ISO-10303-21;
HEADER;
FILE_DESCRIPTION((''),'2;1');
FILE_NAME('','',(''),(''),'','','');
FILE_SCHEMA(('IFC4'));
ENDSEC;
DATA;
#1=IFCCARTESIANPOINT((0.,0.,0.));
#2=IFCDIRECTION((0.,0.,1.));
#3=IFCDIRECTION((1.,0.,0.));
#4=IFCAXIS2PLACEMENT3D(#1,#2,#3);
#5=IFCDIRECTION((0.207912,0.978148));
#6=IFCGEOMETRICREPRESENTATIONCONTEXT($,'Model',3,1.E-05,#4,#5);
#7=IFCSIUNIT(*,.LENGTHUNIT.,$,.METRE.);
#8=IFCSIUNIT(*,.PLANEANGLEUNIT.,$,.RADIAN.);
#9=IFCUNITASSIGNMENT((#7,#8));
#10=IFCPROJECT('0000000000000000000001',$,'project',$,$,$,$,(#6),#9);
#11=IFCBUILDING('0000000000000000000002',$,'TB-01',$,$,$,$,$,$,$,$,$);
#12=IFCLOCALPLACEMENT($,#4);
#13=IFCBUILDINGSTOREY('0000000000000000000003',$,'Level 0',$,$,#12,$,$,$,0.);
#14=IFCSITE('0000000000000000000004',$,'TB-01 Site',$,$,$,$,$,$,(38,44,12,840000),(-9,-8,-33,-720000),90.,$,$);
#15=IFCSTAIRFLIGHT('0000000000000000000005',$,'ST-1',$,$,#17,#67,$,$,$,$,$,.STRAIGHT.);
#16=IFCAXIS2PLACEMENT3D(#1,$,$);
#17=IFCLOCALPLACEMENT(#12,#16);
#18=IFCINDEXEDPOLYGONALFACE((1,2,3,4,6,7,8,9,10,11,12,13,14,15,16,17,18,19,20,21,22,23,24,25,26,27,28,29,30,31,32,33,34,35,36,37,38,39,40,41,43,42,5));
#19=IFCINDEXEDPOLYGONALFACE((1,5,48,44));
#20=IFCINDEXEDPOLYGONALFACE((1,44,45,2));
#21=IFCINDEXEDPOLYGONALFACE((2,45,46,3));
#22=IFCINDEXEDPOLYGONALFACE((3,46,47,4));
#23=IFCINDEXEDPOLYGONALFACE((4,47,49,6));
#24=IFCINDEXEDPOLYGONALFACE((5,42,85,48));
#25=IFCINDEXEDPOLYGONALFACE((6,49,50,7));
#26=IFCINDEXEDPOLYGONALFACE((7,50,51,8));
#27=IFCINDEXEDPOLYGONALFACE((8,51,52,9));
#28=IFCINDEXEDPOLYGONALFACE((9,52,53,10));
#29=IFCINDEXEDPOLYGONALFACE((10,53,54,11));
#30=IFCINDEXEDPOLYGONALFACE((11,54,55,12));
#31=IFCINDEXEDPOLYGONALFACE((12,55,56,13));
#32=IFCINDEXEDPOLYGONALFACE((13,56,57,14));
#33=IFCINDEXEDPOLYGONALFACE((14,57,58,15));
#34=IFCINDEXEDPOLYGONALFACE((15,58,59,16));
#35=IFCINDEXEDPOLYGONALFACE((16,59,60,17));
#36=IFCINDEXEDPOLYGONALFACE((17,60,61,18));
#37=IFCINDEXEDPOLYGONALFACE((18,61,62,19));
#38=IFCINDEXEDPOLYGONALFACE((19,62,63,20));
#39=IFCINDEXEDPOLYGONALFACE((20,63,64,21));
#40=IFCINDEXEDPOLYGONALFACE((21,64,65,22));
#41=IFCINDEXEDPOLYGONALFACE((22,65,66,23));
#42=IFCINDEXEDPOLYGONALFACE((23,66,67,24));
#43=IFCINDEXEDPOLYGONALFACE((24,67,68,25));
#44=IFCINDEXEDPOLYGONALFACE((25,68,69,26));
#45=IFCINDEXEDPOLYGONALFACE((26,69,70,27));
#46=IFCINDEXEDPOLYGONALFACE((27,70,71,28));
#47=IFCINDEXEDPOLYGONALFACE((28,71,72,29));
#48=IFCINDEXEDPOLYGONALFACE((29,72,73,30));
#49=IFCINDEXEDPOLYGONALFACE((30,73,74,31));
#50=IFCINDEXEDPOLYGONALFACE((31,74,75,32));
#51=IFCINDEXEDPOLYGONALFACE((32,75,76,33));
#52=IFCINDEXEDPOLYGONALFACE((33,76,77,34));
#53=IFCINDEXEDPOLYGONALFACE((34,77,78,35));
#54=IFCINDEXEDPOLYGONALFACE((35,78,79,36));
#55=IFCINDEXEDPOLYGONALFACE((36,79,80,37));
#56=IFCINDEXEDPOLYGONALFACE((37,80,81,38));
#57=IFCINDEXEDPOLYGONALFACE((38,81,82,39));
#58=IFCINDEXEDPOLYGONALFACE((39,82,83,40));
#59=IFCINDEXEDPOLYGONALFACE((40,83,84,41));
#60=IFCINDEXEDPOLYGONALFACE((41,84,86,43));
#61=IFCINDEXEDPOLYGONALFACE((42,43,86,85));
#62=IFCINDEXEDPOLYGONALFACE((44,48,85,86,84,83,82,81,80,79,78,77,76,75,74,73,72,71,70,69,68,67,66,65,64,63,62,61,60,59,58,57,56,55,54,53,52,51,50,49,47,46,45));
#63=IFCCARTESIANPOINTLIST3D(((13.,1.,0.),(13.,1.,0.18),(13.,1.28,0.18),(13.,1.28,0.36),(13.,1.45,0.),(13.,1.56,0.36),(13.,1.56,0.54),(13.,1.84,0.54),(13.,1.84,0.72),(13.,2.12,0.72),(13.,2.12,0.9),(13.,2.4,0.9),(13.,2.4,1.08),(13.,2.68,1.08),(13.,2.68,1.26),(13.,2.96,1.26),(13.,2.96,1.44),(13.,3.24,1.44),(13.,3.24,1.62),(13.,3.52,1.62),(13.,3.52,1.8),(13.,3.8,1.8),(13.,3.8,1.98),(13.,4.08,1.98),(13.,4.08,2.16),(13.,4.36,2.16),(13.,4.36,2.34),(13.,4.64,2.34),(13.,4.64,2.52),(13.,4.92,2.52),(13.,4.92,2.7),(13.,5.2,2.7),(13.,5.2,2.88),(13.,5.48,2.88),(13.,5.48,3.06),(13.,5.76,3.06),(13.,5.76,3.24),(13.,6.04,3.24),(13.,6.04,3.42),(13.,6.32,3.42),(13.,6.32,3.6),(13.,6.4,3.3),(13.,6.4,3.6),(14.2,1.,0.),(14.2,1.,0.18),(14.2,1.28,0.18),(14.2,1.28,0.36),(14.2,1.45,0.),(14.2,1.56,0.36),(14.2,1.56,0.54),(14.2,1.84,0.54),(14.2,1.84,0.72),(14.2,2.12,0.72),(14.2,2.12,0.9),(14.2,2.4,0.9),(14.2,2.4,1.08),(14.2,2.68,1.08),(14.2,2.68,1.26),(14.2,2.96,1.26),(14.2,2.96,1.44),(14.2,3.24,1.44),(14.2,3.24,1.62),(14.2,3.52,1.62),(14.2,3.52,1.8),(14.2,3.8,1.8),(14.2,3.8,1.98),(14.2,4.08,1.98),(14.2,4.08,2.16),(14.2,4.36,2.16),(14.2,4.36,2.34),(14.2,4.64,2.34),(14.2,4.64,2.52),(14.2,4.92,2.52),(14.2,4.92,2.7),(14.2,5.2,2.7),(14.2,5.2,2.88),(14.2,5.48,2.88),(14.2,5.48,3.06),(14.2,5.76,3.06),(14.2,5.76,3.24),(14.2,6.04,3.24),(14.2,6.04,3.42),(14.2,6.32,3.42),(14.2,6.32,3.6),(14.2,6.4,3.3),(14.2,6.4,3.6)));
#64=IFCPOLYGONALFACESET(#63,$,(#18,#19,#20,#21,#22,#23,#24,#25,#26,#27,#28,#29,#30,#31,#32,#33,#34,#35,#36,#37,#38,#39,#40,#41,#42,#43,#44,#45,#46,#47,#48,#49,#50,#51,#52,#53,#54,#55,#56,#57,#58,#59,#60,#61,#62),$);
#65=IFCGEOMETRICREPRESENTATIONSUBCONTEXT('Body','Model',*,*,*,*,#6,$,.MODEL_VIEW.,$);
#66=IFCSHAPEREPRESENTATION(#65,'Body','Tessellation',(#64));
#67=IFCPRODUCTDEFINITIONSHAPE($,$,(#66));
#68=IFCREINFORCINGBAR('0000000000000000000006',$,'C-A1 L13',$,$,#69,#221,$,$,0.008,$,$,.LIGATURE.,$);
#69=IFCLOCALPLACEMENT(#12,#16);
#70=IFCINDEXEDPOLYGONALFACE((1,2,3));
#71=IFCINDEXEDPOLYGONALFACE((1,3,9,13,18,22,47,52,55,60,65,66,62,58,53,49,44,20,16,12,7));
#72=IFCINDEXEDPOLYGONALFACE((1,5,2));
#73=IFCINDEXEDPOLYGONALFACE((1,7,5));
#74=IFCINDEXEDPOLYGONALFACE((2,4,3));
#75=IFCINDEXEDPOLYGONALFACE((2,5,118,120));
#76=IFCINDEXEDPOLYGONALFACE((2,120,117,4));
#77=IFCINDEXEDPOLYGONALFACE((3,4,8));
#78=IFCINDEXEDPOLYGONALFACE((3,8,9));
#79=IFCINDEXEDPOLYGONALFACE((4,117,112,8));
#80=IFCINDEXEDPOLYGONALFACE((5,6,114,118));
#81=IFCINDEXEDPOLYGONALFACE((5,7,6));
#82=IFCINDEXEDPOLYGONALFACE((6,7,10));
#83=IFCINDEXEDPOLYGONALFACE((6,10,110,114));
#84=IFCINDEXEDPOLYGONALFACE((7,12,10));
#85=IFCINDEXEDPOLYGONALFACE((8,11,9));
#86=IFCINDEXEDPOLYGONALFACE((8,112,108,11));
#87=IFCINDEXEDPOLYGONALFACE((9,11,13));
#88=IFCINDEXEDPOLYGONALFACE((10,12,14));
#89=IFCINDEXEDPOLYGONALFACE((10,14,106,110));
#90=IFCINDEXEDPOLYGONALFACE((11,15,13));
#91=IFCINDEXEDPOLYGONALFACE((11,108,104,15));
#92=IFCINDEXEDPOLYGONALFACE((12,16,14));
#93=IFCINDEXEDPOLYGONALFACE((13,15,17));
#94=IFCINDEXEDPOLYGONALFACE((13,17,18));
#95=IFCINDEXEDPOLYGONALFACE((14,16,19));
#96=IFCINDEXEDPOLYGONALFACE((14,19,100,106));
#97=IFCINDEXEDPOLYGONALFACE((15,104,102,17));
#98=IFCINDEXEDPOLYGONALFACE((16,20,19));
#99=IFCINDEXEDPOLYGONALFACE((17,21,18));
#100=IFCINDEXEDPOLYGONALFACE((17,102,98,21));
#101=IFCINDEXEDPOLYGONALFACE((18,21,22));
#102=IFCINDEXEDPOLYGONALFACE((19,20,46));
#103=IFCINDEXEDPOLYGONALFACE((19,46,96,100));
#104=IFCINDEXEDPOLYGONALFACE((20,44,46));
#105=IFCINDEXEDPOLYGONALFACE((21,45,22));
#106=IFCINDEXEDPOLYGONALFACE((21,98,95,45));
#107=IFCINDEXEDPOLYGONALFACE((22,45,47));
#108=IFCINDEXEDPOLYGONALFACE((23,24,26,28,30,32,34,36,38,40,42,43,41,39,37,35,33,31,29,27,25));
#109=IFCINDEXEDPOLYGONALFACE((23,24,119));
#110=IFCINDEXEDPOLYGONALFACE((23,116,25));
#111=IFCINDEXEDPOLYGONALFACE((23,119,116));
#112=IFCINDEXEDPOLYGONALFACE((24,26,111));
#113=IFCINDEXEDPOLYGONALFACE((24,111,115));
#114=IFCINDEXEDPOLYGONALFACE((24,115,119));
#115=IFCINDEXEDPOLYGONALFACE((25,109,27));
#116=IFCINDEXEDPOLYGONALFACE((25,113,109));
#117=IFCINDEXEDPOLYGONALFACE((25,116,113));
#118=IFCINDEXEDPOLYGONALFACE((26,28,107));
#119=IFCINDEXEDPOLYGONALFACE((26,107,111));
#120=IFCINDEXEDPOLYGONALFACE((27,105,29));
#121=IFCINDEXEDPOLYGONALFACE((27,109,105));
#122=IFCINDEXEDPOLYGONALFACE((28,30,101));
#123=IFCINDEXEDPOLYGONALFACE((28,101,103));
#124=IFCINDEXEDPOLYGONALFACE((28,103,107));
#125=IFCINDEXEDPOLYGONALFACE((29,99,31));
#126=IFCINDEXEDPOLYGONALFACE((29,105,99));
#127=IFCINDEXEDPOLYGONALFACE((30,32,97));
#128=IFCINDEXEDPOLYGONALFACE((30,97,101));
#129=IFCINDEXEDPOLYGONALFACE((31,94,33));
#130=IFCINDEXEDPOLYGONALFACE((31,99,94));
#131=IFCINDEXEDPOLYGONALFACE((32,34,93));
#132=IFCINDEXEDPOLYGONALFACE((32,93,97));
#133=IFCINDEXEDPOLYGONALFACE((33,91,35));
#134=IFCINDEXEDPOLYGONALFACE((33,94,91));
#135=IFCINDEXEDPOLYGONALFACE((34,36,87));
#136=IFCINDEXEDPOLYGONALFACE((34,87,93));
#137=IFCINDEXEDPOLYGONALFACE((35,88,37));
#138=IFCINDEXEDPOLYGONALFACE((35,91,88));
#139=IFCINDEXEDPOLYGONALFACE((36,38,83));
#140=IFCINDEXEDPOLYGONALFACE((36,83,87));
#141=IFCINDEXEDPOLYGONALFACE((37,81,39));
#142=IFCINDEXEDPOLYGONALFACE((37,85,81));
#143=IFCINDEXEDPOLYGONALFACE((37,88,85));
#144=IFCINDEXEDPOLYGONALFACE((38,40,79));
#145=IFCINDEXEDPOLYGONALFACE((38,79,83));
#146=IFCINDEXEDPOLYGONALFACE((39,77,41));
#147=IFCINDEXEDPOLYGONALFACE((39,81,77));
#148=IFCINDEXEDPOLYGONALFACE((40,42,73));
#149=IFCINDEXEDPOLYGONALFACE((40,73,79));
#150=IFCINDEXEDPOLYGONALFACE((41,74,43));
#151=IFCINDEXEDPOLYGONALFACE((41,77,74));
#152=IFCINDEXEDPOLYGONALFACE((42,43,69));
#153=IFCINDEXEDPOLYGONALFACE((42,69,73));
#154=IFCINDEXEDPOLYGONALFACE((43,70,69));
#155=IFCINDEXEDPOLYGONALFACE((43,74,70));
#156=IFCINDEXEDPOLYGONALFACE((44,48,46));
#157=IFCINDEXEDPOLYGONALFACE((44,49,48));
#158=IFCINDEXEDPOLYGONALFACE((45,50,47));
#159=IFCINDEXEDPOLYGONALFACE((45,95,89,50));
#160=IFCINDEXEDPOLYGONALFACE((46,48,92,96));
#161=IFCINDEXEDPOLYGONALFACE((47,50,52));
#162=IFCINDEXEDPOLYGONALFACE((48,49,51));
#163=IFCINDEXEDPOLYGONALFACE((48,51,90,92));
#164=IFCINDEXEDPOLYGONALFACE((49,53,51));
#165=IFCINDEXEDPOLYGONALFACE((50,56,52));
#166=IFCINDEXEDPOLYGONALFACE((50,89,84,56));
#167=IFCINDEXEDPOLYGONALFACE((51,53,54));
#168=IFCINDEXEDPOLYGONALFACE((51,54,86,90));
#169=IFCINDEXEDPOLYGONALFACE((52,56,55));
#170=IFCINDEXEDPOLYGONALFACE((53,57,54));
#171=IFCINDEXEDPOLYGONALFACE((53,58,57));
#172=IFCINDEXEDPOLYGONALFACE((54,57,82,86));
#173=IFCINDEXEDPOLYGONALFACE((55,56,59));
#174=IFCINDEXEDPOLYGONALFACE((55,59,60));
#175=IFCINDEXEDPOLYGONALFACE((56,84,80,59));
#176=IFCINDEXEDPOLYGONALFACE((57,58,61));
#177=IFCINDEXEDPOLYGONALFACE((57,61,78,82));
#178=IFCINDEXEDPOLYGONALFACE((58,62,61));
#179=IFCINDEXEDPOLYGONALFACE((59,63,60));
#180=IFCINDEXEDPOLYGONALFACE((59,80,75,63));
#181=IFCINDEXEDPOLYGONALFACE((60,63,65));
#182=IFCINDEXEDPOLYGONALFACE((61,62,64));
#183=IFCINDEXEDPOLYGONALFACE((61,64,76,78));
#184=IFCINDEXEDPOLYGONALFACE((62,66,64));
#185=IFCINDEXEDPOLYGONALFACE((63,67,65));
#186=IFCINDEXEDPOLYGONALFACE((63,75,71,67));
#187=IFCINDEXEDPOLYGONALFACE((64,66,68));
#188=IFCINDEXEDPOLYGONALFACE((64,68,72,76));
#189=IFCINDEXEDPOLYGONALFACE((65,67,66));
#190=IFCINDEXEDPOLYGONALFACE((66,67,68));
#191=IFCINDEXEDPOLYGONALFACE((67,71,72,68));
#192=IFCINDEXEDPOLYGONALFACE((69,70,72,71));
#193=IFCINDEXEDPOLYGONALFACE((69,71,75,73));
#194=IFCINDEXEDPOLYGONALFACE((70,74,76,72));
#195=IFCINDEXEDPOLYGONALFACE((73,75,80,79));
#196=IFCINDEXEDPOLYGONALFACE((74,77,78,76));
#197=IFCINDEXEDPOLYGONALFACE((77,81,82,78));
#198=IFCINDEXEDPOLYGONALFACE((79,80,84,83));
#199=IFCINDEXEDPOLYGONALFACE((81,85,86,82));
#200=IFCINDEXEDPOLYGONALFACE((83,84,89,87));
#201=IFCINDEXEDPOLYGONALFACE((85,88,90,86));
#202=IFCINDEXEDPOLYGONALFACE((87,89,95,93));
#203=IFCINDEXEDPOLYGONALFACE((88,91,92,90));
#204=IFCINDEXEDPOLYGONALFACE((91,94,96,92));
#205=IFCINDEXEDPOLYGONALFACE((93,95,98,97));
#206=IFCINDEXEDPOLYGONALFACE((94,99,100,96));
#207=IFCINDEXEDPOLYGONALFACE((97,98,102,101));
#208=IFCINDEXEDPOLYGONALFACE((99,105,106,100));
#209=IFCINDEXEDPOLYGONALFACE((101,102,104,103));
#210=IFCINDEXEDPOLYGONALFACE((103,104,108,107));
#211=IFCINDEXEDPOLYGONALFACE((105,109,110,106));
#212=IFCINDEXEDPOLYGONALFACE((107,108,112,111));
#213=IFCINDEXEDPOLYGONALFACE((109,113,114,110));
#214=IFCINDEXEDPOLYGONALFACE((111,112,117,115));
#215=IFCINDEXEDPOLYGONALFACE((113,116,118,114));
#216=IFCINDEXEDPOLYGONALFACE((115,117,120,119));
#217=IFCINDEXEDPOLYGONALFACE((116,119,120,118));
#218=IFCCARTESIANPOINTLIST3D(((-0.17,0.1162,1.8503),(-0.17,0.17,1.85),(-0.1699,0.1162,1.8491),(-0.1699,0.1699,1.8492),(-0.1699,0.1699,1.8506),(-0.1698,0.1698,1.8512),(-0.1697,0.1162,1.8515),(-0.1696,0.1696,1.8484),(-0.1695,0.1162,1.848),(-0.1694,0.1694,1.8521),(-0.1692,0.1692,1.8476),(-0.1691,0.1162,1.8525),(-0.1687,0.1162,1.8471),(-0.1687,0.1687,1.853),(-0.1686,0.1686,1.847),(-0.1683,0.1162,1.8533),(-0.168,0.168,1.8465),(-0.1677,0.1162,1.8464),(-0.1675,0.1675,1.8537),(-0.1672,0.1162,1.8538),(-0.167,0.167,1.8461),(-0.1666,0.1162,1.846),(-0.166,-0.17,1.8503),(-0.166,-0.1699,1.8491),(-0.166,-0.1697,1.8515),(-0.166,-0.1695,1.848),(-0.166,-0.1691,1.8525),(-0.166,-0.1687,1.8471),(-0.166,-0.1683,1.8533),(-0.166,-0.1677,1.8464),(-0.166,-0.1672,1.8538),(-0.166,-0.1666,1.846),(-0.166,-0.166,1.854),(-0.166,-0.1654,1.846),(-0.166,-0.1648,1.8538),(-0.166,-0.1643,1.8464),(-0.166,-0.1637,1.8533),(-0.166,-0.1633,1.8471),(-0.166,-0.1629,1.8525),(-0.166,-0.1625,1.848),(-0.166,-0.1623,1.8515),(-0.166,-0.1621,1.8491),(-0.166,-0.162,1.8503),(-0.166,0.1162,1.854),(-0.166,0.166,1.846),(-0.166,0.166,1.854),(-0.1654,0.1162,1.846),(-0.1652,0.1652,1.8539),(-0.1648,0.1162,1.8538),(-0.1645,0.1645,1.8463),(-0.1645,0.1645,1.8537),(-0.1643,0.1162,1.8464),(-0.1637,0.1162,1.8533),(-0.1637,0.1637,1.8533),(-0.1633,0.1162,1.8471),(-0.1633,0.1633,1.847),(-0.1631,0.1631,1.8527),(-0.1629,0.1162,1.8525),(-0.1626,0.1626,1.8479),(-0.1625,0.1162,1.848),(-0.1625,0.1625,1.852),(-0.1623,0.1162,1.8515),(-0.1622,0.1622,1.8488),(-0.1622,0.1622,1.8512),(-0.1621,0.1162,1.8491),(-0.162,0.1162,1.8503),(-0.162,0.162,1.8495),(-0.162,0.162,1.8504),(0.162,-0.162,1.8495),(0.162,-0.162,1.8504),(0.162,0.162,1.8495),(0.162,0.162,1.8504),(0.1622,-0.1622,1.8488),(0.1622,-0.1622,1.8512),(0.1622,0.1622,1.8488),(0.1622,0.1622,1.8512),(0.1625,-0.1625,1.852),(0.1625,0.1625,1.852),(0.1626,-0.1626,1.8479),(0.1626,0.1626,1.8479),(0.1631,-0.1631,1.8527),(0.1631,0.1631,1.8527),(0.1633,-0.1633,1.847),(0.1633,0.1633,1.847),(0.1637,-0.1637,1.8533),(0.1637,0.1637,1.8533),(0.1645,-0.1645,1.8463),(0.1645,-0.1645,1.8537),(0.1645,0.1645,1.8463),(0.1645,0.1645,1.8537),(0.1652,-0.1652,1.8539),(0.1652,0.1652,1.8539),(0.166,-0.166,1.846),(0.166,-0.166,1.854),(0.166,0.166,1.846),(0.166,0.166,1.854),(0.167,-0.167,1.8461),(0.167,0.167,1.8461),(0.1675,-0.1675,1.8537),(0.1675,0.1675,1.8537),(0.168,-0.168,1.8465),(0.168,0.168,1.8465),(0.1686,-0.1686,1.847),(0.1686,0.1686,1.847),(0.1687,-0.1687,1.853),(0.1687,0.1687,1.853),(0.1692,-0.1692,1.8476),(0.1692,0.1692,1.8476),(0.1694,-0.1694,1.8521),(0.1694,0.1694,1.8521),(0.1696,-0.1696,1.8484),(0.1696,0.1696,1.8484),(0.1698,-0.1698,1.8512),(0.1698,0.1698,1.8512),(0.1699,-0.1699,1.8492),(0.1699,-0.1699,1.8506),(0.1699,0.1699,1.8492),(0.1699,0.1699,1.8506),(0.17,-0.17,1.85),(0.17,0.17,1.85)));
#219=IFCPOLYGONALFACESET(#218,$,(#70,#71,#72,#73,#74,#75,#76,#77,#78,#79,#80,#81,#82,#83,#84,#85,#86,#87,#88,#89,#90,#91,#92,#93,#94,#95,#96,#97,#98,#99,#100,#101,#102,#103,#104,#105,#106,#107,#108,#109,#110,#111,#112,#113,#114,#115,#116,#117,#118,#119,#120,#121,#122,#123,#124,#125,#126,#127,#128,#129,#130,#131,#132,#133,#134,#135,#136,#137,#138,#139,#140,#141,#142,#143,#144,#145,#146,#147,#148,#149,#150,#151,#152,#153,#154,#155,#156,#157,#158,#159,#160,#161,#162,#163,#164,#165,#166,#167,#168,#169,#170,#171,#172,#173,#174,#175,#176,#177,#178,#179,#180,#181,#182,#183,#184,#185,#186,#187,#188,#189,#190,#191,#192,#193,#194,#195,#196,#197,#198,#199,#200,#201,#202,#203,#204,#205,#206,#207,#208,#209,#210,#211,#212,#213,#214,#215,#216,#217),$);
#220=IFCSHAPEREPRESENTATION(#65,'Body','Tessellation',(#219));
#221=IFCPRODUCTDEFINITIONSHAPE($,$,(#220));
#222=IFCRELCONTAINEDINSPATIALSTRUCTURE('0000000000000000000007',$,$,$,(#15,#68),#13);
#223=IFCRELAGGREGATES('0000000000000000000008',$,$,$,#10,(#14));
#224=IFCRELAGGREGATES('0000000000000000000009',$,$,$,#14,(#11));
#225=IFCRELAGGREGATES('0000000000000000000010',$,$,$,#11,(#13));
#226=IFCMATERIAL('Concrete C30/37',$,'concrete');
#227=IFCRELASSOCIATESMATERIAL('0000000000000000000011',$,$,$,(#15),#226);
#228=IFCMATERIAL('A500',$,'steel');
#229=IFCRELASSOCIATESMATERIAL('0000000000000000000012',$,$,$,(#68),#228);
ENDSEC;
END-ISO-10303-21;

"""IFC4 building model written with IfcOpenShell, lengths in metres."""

from ifc_helpers import new_model, entity, si_unit, direction, frame, origin_with_axes, place, context, subcontext, project, spatial, polyline, outline, extrude, material, element, save


model = new_model("IFC4")

# Units and contexts
model_context = context("Model", 3, precision=1e-05, world=origin_with_axes(), true_north=direction((0.207912, 0.978148)))
body_context = subcontext(model_context, "Body", "Model", "MODEL_VIEW")
ifc_project = project(units=[si_unit("LENGTHUNIT", "METRE"), si_unit("PLANEANGLEUNIT", "RADIAN")], contexts=[model_context])

# Site, building, storey
site = spatial("IfcSite", under=ifc_project, Name="TB-01 Site", RefLatitude=(38, 44, 12, 840000), RefLongitude=(-9, -8, -33, -720000), RefElevation=90.0)
building = spatial("IfcBuilding", under=site, Name="TB-01")
storey_placement = place(None, origin_with_axes())
storey = spatial("IfcBuildingStorey", under=building, at=storey_placement, Name="Level 0", Elevation=0.0)

# Shared definitions
ifc_material_1 = material(Name="Concrete C30/37", Category="concrete")

# Stair flight
stair_flight_placement = place(storey_placement, frame((13.0, 1.0, 0.0), z_axis=(1.0, 0.0, 0.0), x_axis=(0.0, 1.0, 0.0)))
element("IfcStairFlight", 1, at=stair_flight_placement, inside=storey, material=ifc_material_1, Name="ST-1", PredefinedType="STRAIGHT", context=body_context, shape_type="SweptSolid", body=[
    extrude(outline(polyline([(0.0, 0.0), (0.0, 0.18), (0.28, 0.18), (0.28, 0.36), (0.56, 0.36), (0.56, 0.54), (0.84, 0.54), (0.84, 0.72), (1.12, 0.72), (1.12, 0.9), (1.4, 0.9), (1.4, 1.08), (1.68, 1.08), (1.68, 1.26), (1.96, 1.26), (1.96, 1.44), (2.24, 1.44), (2.24, 1.62), (2.52, 1.62), (2.52, 1.8), (2.8, 1.8), (2.8, 1.98), (3.08, 1.98), (3.08, 2.16), (3.36, 2.16), (3.36, 2.34), (3.64, 2.34), (3.64, 2.52), (3.92, 2.52), (3.92, 2.7), (4.2, 2.7), (4.2, 2.88), (4.48, 2.88), (4.48, 3.06), (4.76, 3.06), (4.76, 3.24), (5.04, 3.24), (5.04, 3.42), (5.32, 3.42), (5.32, 3.6), (5.4, 3.6), (5.4, 3.3), (0.45, 0.0), (0.0, 0.0)])), origin_with_axes(), (0.0, 0.0, 1.0), 1.2),
])

# Reinforcing bar
ifc_material_2 = material(Name="A500", Category="steel")
reinforcing_bar_1_placement = place(storey_placement, origin_with_axes())
element("IfcReinforcingBar", 2, at=reinforcing_bar_1_placement, inside=storey, material=ifc_material_2, Name="C-A1 L13", NominalDiameter=0.008, PredefinedType="LIGATURE", context=body_context, shape_type="AdvancedSweptSolid", body=[
    entity("IfcSweptDiskSolid", entity("IfcPolyline", [entity("IfcCartesianPoint", [-0.166, -0.166, 1.85]), entity("IfcCartesianPoint", [0.166, -0.166, 1.85]), entity("IfcCartesianPoint", [0.166, 0.166, 1.85]), entity("IfcCartesianPoint", [-0.166, 0.166, 1.85]), entity("IfcCartesianPoint", [-0.166, 0.1162, 1.85])]), 0.004),
])

save(model, "model.ifc")
